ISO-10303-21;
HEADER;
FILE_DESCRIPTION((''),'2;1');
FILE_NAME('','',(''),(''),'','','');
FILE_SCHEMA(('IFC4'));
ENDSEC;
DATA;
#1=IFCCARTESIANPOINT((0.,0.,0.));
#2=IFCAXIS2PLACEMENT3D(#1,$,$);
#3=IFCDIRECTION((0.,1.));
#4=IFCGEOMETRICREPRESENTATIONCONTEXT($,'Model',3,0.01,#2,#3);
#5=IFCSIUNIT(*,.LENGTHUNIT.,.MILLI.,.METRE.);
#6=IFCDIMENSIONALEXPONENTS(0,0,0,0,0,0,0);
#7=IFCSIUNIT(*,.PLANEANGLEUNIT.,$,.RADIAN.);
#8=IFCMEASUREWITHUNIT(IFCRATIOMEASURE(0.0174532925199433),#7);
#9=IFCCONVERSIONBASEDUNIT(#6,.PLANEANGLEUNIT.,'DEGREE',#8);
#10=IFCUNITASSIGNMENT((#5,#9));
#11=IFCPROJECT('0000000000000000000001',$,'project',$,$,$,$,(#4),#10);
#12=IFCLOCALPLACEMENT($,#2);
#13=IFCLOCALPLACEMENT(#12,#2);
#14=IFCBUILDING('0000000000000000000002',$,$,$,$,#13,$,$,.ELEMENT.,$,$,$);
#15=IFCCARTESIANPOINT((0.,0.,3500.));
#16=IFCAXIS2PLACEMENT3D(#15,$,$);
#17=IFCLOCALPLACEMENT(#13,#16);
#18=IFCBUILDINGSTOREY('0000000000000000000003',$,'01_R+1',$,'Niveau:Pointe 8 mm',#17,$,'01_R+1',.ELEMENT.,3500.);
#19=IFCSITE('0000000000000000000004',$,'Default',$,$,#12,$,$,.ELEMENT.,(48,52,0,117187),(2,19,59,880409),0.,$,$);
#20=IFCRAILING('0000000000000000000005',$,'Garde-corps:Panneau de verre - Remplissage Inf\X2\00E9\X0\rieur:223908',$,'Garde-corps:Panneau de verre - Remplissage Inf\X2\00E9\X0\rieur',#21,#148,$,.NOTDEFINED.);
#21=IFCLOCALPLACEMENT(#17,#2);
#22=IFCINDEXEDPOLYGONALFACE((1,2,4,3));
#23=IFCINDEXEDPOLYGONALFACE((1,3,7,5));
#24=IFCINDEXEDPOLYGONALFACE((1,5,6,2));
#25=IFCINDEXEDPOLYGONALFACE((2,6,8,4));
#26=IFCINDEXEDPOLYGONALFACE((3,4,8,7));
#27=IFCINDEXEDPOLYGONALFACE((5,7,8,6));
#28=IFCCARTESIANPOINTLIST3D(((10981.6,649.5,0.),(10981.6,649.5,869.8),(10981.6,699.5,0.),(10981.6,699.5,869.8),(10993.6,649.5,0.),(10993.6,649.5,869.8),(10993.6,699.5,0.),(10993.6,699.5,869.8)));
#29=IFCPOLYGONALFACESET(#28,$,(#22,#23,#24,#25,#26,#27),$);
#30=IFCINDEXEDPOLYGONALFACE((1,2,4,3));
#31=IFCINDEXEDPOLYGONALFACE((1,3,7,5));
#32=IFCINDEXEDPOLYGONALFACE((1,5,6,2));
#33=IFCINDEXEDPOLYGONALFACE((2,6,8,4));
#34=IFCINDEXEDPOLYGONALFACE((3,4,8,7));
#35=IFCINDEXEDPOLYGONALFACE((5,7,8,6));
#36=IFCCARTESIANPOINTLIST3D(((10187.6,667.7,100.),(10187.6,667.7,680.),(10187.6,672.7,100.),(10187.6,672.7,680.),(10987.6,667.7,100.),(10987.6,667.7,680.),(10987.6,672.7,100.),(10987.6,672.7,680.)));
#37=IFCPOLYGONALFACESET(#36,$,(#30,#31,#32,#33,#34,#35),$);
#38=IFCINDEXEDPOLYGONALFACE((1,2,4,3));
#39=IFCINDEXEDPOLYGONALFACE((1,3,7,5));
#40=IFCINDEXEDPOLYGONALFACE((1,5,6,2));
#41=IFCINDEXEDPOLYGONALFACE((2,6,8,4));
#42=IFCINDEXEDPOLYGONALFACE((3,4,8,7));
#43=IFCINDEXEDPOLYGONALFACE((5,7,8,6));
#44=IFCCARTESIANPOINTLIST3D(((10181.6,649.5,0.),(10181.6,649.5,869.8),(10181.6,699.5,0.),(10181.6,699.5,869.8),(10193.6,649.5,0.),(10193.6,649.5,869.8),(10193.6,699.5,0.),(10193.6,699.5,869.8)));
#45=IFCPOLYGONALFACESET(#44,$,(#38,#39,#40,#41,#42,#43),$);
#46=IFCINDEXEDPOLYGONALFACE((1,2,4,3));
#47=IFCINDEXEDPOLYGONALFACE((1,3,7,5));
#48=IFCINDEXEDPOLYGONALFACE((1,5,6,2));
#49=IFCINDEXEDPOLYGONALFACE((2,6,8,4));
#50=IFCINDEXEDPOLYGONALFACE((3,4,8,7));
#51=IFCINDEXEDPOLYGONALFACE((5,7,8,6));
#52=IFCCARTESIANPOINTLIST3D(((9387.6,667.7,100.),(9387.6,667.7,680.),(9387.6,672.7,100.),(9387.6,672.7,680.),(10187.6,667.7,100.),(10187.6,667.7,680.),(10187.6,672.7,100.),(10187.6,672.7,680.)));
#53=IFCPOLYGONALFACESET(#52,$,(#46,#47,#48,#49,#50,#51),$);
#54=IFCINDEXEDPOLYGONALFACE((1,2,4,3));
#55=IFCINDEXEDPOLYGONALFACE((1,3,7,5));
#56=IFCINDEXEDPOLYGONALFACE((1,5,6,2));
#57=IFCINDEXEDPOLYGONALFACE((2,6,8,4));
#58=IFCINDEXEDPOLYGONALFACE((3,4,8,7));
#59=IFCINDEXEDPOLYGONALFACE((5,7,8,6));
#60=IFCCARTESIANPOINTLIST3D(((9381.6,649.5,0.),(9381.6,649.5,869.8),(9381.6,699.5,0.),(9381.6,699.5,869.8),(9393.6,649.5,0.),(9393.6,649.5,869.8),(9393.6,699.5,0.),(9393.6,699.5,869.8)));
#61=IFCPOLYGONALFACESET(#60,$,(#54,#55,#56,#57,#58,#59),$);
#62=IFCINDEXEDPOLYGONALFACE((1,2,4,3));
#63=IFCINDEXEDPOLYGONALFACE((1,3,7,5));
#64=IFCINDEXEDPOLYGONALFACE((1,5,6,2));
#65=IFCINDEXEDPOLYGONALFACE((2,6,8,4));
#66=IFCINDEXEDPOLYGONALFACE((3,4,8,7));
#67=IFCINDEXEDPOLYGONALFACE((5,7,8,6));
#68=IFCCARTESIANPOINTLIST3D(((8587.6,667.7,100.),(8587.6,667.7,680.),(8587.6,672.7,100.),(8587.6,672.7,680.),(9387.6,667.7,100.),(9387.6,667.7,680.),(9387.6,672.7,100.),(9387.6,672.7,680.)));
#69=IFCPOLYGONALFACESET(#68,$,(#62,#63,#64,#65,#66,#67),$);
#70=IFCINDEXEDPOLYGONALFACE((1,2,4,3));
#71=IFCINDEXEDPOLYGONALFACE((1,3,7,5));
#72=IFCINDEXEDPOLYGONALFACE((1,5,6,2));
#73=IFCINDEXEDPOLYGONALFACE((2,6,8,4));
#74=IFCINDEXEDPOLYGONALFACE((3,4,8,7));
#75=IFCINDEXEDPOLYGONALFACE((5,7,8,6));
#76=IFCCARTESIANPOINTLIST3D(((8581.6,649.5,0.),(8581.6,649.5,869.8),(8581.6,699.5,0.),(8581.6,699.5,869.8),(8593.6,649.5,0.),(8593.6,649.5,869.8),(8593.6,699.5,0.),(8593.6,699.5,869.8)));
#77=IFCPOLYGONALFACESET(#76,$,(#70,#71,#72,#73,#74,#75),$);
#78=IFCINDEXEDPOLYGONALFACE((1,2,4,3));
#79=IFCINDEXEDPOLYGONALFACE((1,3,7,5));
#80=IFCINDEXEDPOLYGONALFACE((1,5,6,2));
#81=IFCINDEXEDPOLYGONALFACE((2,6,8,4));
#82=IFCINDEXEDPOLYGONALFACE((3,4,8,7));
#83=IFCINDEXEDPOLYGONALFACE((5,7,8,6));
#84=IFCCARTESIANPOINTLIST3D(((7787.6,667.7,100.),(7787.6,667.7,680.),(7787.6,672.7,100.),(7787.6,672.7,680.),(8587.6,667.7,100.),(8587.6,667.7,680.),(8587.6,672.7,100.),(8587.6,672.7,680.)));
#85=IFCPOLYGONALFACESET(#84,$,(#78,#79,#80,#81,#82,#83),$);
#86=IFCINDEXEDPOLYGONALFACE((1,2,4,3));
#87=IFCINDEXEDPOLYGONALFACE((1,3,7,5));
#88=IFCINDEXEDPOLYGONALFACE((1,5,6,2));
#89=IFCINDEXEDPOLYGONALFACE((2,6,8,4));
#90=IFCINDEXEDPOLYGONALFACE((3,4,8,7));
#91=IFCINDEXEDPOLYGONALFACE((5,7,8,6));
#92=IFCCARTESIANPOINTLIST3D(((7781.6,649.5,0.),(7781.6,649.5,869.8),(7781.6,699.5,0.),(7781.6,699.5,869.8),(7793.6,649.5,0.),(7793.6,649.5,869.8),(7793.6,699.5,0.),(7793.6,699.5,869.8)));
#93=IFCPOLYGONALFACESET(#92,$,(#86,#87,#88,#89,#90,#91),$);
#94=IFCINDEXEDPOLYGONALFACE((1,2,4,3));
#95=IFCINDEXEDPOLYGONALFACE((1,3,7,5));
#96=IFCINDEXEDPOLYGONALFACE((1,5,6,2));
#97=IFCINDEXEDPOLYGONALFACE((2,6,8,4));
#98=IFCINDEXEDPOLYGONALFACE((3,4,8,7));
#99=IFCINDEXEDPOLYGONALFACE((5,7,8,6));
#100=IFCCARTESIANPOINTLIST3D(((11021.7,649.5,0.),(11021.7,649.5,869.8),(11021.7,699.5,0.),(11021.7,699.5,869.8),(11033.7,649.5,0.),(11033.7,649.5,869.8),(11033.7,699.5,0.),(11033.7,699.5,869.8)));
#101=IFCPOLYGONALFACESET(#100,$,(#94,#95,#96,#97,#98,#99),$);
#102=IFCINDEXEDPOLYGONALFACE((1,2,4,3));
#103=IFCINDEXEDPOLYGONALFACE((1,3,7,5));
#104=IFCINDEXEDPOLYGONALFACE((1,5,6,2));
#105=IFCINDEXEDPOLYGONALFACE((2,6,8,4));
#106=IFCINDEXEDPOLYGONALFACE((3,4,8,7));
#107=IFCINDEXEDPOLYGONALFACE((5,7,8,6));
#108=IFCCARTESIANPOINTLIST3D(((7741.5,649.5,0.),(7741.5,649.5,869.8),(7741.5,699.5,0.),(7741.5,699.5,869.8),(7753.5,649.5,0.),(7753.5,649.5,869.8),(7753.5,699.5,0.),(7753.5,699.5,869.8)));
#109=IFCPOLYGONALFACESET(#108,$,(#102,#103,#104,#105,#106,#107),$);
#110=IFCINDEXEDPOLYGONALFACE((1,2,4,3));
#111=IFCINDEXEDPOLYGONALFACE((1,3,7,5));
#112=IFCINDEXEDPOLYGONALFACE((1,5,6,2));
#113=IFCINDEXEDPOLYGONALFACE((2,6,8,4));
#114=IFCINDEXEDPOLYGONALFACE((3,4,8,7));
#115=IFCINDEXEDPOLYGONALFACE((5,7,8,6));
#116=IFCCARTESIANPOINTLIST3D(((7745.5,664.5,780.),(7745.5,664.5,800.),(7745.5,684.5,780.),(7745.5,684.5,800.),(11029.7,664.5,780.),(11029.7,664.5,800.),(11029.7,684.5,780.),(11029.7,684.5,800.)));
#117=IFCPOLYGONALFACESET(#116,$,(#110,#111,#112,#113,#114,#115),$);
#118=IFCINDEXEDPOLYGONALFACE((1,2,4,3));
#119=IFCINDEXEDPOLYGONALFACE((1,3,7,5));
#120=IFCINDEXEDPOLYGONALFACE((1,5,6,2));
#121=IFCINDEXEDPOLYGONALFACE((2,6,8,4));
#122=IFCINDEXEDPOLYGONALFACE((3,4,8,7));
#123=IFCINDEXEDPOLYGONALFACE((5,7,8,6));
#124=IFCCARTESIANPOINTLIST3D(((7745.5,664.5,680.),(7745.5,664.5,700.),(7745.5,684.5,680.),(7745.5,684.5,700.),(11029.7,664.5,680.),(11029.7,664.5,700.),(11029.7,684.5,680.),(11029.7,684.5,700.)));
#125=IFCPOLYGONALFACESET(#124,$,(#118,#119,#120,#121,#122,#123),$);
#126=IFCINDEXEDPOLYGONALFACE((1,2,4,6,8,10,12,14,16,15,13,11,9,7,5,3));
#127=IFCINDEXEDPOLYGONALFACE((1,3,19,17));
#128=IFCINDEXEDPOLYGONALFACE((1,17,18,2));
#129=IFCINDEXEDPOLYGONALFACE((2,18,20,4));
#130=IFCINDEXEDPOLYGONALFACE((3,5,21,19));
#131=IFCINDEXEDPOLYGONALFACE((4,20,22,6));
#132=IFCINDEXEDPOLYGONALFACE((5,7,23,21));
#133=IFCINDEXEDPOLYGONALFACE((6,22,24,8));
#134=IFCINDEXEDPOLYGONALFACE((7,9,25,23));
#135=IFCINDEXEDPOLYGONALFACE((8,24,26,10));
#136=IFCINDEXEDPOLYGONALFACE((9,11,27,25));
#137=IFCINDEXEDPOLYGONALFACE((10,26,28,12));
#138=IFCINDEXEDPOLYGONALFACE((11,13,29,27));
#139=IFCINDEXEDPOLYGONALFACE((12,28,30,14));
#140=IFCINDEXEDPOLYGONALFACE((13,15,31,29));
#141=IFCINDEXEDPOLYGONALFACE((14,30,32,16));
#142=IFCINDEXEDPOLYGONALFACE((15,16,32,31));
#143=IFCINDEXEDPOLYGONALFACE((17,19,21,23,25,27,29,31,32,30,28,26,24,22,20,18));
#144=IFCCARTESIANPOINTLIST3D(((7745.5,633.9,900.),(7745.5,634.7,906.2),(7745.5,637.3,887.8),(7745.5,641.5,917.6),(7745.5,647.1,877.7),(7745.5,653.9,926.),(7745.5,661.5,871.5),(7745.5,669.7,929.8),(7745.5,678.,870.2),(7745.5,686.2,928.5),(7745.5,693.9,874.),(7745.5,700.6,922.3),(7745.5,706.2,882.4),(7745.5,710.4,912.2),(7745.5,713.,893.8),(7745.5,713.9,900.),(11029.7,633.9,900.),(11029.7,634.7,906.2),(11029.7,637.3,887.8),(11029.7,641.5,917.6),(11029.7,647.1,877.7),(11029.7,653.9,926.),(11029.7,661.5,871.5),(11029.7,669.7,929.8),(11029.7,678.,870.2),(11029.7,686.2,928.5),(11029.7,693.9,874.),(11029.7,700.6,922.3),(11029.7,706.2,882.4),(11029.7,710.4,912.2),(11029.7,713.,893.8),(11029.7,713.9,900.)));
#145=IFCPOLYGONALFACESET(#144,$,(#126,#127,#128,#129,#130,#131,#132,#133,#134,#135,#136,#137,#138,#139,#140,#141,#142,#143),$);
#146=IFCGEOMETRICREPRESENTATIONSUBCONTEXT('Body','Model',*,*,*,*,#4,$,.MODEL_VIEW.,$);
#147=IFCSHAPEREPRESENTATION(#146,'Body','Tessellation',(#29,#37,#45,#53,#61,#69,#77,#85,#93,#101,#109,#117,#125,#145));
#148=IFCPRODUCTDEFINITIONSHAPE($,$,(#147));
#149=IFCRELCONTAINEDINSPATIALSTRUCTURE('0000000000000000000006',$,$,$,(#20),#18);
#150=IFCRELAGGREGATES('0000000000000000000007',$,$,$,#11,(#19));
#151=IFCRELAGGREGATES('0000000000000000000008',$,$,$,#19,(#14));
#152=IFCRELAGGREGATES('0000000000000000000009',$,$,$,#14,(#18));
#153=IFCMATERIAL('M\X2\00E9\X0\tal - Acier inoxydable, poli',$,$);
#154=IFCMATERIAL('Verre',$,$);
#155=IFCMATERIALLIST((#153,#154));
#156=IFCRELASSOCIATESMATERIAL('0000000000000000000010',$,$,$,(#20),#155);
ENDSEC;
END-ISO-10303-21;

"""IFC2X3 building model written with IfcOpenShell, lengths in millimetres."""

from ifc_helpers import new_model, entity, si_unit, converted_unit, direction, frame, frame_2d, origin, place, context, subcontext, project, spatial, polyline, rectangle, outline, extrude, material, material_list, element, save


model = new_model("IFC2X3")

# Units and contexts
model_context = context("Model", 3, precision=0.01, world=origin(), true_north=direction((0.0, 1.0)))
body_context = subcontext(model_context, "Body", "Model", "MODEL_VIEW")
ifc_project = project(units=[si_unit("LENGTHUNIT", "METRE", prefix="MILLI"), converted_unit("PLANEANGLEUNIT", "DEGREE", entity("IfcRatioMeasure", 0.0174532925199433), si_unit("PLANEANGLEUNIT", "RADIAN"), dimensions=[0, 0, 0, 0, 0, 0, 0])], contexts=[model_context])

# Site, building, storey
site_placement = place(None, origin())
site = spatial("IfcSite", under=ifc_project, at=site_placement, Name="Default", CompositionType="ELEMENT", RefLatitude=(48, 52, 0, 117187), RefLongitude=(2, 19, 59, 880409), RefElevation=0.0)
building_placement = place(site_placement, origin())
building = spatial("IfcBuilding", under=site, at=building_placement, CompositionType="ELEMENT")
storey_placement = place(building_placement, frame((0.0, 0.0, 3500.0)))
storey = spatial("IfcBuildingStorey", under=building, at=storey_placement, Name="01_R+1", ObjectType="Niveau:Pointe 8 mm", LongName="01_R+1", CompositionType="ELEMENT", Elevation=3500.0)

# Railing
ifc_material_1 = material(Name="Métal - Acier inoxydable, poli")
ifc_material_2 = material(Name="Verre")
ifc_material_list_1 = material_list([ifc_material_1, ifc_material_2])
railing_1_placement = place(storey_placement, origin())
element("IfcRailing", 1, at=railing_1_placement, inside=storey, material=ifc_material_list_1, Name="Garde-corps:Panneau de verre - Remplissage Inférieur:223908", ObjectType="Garde-corps:Panneau de verre - Remplissage Inférieur", PredefinedType="NOTDEFINED", context=body_context, shape_type="SweptSolid", body=[
    extrude(rectangle(XDim=50.0, YDim=12.0, at=frame_2d((0.0, 0.0), x_axis=(1.0, 0.0))), frame((10987.6, 674.5, 0.0), z_axis=(0.0, 0.0, 1.0), x_axis=(0.0, -1.0, 0.0)), (0.0, 0.0, 1.0), 869.8),
    extrude(rectangle(XDim=5.0, YDim=800.0, at=frame_2d((0.0, 0.0), x_axis=(1.0, 0.0))), frame((10587.6, 670.2, 100.0), z_axis=(0.0, 0.0, 1.0), x_axis=(0.0, -1.0, 0.0)), (0.0, 0.0, 1.0), 580.0),
    extrude(rectangle(XDim=50.0, YDim=12.0, at=frame_2d((0.0, 0.0), x_axis=(1.0, 0.0))), frame((10187.6, 674.5, 0.0), z_axis=(0.0, 0.0, 1.0), x_axis=(0.0, -1.0, 0.0)), (0.0, 0.0, 1.0), 869.8),
    extrude(rectangle(XDim=5.0, YDim=800.0, at=frame_2d((0.0, 0.0), x_axis=(1.0, 0.0))), frame((9787.6, 670.2, 100.0), z_axis=(0.0, 0.0, 1.0), x_axis=(0.0, -1.0, 0.0)), (0.0, 0.0, 1.0), 580.0),
    extrude(rectangle(XDim=50.0, YDim=12.0, at=frame_2d((0.0, 0.0), x_axis=(1.0, 0.0))), frame((9387.6, 674.5, 0.0), z_axis=(0.0, 0.0, 1.0), x_axis=(0.0, -1.0, 0.0)), (0.0, 0.0, 1.0), 869.8),
    extrude(rectangle(XDim=5.0, YDim=800.0, at=frame_2d((0.0, 0.0), x_axis=(1.0, 0.0))), frame((8987.6, 670.2, 100.0), z_axis=(0.0, 0.0, 1.0), x_axis=(0.0, -1.0, 0.0)), (0.0, 0.0, 1.0), 580.0),
    extrude(rectangle(XDim=50.0, YDim=12.0, at=frame_2d((0.0, 0.0), x_axis=(1.0, 0.0))), frame((8587.6, 674.5, 0.0), z_axis=(0.0, 0.0, 1.0), x_axis=(0.0, -1.0, 0.0)), (0.0, 0.0, 1.0), 869.8),
    extrude(rectangle(XDim=5.0, YDim=800.0, at=frame_2d((0.0, 0.0), x_axis=(1.0, 0.0))), frame((8187.6, 670.2, 100.0), z_axis=(0.0, 0.0, 1.0), x_axis=(0.0, -1.0, 0.0)), (0.0, 0.0, 1.0), 580.0),
    extrude(rectangle(XDim=50.0, YDim=12.0, at=frame_2d((0.0, 0.0), x_axis=(1.0, 0.0))), frame((7787.6, 674.5, 0.0), z_axis=(0.0, 0.0, 1.0), x_axis=(0.0, -1.0, 0.0)), (0.0, 0.0, 1.0), 869.8),
    extrude(rectangle(XDim=50.0, YDim=12.0, at=frame_2d((0.0, 0.0), x_axis=(1.0, 0.0))), frame((11027.7, 674.5, 0.0), z_axis=(0.0, 0.0, 1.0), x_axis=(0.0, -1.0, 0.0)), (0.0, 0.0, 1.0), 869.8),
    extrude(rectangle(XDim=50.0, YDim=12.0, at=frame_2d((0.0, 0.0), x_axis=(1.0, 0.0))), frame((7747.5, 674.5, 0.0), z_axis=(0.0, 0.0, 1.0), x_axis=(0.0, -1.0, 0.0)), (0.0, 0.0, 1.0), 869.8),
    extrude(rectangle(XDim=3284.2, YDim=20.0, at=frame_2d((0.0, 0.0), x_axis=(1.0, 0.0))), frame((9387.6, 674.5, 780.0)), (0.0, 0.0, 1.0), 20.0),
    extrude(rectangle(XDim=3284.2, YDim=20.0, at=frame_2d((0.0, 0.0), x_axis=(1.0, 0.0))), frame((9387.6, 674.5, 680.0)), (0.0, 0.0, 1.0), 20.0),
    extrude(outline(polyline([(-10.9, -38.5), (1.8, -38.5), (14.2, -31.8), (24.1, -19.7), (29.8, -4.1), (30.4, 12.2), (25.8, 26.3), (16.7, 35.9), (10.9, 38.5), (-1.8, 38.5), (-14.2, 31.8), (-24.1, 19.7), (-29.8, 4.1), (-30.4, -12.2), (-25.8, -26.3), (-16.7, -35.9), (-10.9, -38.5)])), frame((7745.5, 673.9, 900.0), z_axis=(1.0, 0.0, 0.0), x_axis=(0.0, 0.27267, -0.962108)), (0.0, 0.0, 1.0), 3284.2),
])

save(model, "model.ifc")
